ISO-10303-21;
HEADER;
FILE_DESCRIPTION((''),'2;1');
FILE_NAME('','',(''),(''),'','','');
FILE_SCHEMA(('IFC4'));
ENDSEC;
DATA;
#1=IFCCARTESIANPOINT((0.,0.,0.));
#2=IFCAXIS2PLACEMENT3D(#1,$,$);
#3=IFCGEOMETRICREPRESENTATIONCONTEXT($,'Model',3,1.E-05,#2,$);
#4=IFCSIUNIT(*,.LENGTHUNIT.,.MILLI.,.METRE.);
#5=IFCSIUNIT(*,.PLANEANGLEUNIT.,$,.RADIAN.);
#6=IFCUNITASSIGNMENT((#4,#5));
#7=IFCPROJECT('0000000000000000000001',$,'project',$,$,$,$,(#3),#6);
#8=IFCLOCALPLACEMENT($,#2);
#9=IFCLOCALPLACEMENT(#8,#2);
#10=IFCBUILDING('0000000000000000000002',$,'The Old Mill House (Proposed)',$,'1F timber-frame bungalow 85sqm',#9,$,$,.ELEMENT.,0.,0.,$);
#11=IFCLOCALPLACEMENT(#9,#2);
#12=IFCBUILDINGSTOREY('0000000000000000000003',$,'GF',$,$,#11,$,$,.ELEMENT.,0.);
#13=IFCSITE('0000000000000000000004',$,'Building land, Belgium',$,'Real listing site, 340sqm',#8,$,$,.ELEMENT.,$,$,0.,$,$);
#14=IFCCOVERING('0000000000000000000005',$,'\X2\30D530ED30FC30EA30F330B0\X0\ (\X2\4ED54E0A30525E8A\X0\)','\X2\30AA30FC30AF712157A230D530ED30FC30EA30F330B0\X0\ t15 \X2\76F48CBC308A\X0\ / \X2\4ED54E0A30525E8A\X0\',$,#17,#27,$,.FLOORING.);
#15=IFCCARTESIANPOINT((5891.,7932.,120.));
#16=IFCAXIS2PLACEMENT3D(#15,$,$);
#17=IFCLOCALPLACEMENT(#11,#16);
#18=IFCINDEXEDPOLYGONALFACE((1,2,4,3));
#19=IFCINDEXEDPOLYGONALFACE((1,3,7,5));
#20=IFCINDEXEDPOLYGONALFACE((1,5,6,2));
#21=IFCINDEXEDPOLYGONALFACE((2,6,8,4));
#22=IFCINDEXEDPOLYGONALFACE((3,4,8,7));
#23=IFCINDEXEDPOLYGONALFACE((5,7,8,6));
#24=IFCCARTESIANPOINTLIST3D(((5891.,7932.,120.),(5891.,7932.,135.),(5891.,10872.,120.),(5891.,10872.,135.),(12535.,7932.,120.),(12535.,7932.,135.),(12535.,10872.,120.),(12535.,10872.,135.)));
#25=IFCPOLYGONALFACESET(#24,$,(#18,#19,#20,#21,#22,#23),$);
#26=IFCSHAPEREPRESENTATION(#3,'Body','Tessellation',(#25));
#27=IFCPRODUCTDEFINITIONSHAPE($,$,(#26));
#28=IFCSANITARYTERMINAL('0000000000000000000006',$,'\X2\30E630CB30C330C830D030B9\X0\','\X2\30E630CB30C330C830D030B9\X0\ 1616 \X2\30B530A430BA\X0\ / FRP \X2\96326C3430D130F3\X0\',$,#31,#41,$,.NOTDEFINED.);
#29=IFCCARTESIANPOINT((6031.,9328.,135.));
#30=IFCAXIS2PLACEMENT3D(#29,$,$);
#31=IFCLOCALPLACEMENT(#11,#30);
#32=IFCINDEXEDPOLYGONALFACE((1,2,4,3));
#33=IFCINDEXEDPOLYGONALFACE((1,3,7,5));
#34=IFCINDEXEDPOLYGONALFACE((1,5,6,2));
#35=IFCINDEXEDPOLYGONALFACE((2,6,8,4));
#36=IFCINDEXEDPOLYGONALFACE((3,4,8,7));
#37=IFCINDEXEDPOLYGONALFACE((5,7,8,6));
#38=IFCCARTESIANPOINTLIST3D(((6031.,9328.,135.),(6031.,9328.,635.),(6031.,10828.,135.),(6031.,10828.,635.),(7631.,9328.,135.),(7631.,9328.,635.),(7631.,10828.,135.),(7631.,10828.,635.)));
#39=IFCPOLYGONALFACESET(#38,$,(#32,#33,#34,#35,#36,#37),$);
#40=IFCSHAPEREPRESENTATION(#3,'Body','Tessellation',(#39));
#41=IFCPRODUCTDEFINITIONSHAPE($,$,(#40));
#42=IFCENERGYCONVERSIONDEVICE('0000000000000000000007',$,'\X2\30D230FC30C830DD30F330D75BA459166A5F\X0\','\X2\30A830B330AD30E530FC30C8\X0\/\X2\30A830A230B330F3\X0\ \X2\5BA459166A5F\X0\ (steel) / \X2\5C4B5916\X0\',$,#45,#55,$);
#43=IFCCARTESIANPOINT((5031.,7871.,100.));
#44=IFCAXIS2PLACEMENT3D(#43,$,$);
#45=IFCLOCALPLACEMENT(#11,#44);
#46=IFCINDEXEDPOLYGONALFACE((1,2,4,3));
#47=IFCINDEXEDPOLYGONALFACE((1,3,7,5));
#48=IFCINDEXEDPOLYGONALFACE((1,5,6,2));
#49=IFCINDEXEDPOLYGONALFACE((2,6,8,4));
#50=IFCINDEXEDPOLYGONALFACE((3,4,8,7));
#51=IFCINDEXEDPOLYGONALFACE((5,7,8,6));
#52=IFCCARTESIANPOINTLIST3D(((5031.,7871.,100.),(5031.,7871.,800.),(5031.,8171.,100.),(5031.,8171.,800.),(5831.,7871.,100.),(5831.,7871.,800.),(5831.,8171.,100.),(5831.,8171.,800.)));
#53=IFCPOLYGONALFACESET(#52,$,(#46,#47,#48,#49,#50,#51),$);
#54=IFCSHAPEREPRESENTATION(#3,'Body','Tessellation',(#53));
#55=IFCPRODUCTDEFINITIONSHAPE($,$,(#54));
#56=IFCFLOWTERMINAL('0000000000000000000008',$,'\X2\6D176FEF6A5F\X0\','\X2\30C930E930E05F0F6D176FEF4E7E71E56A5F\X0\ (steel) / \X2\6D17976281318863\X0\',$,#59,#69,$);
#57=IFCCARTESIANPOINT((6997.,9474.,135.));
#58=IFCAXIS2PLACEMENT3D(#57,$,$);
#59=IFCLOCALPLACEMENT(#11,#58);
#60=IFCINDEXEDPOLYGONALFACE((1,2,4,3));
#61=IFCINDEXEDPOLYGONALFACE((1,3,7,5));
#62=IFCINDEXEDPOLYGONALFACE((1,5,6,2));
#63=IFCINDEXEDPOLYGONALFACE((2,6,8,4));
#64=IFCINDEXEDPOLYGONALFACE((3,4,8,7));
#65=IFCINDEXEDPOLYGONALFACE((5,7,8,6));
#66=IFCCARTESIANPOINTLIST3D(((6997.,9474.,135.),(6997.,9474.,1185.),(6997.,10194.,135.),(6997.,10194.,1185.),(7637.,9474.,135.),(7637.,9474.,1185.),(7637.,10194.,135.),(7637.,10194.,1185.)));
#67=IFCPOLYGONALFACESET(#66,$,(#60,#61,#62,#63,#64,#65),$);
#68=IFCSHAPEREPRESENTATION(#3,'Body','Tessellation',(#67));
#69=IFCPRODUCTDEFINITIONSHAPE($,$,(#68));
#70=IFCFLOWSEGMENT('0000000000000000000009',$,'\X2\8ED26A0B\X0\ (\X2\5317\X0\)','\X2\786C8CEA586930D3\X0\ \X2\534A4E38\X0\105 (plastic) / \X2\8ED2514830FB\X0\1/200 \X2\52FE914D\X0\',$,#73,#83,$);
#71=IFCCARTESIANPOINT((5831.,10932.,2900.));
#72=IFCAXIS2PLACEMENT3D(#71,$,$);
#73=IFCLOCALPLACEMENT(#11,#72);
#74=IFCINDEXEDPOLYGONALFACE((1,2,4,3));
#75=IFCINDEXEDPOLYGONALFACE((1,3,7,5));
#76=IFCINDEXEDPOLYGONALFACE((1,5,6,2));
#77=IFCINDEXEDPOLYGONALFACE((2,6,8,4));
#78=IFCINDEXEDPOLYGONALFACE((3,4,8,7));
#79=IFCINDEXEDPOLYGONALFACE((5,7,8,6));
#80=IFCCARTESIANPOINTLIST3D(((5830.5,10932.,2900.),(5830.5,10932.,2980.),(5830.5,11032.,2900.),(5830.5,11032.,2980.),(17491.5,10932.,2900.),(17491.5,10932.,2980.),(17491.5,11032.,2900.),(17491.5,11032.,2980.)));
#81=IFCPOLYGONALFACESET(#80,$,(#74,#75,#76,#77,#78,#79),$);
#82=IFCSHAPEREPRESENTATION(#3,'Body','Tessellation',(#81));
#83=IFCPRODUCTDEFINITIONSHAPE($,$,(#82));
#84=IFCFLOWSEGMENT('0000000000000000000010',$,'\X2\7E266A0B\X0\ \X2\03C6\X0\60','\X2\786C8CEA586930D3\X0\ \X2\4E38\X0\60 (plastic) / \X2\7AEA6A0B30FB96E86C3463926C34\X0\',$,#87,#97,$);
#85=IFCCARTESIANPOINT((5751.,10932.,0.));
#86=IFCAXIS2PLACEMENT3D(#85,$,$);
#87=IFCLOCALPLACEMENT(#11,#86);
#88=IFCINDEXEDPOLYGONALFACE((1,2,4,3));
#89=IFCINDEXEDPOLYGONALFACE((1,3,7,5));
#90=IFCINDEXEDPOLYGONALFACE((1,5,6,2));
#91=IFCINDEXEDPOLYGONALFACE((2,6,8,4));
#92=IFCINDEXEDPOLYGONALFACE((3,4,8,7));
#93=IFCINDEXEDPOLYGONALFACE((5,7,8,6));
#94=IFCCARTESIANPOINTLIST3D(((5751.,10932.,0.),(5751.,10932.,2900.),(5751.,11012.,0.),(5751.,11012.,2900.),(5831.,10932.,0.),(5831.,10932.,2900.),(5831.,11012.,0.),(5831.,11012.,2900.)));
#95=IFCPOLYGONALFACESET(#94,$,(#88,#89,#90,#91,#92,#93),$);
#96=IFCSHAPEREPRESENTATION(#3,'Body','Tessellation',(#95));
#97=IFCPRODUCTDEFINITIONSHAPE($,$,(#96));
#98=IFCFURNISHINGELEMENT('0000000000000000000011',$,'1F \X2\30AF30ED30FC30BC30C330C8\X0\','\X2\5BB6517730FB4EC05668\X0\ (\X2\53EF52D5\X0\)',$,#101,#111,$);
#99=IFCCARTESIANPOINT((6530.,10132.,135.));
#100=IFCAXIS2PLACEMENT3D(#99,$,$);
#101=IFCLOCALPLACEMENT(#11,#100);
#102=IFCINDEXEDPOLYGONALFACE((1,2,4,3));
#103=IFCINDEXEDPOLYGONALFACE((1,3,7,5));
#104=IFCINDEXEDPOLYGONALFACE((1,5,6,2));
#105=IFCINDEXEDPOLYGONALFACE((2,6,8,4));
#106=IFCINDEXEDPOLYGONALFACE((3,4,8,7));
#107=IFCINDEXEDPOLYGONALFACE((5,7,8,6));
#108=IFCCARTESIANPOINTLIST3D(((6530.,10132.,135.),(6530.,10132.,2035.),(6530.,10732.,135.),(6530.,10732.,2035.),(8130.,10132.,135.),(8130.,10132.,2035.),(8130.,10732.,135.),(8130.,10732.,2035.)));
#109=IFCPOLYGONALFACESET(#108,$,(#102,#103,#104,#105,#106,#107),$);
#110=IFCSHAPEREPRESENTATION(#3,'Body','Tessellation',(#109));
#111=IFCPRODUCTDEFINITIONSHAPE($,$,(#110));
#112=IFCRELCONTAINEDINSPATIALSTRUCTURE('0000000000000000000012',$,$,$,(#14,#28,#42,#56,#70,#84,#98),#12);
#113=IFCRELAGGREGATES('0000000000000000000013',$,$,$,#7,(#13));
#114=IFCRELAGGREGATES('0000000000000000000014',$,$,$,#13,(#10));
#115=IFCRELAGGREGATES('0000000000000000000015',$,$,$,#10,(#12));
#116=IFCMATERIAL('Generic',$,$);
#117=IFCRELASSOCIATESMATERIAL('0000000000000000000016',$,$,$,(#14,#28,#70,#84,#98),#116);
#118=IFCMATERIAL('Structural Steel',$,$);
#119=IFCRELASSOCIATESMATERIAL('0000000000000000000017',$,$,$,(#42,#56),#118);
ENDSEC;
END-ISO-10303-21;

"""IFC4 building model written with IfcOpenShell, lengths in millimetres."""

from ifc_helpers import new_model, si_unit, frame, frame_2d, origin, place, context, project, spatial, rectangle, extrude, material, element, save


model = new_model("IFC4")

# Units and contexts
model_context = context("Model", 3, precision=1e-05, world=origin())
ifc_project = project(units=[si_unit("LENGTHUNIT", "METRE", prefix="MILLI"), si_unit("PLANEANGLEUNIT", "RADIAN")], contexts=[model_context])

# Site, building, storey
site_placement = place(None, origin())
site = spatial("IfcSite", under=ifc_project, at=site_placement, Name="Building land, Belgium", ObjectType="Real listing site, 340sqm", CompositionType="ELEMENT", RefElevation=0.0)
building_placement = place(site_placement, origin())
building = spatial("IfcBuilding", under=site, at=building_placement, Name="The Old Mill House (Proposed)", ObjectType="1F timber-frame bungalow 85sqm", CompositionType="ELEMENT", ElevationOfRefHeight=0.0, ElevationOfTerrain=0.0)
storey_placement = place(building_placement, origin())
storey = spatial("IfcBuildingStorey", under=building, at=storey_placement, Name="GF", CompositionType="ELEMENT", Elevation=0.0)

# Shared definitions
ifc_material_1 = material(Name="Structural Steel")

# Covering
ifc_material_2 = material(Name="Generic")
covering_placement = place(storey_placement, frame((5891.0, 7932.0, 120.0)))
element("IfcCovering", 1, at=covering_placement, inside=storey, material=ifc_material_2, Name="フローリング (仕上げ床)", Description="オーク無垢フローリング t15 直貼り / 仕上げ床", PredefinedType="FLOORING", context=model_context, shape_type="SweptSolid", body=[
    extrude(rectangle(XDim=6644.0, YDim=2940.0, at=frame_2d((3322.0, 1470.0))), frame((5891.0, 7932.0, 120.0)), (0.0, 0.0, 1.0), 15.0),
])

# Sanitary terminal
sanitary_terminal_placement = place(storey_placement, frame((6031.0, 9328.0, 135.0)))
element("IfcSanitaryTerminal", 2, at=sanitary_terminal_placement, inside=storey, material=ifc_material_2, Name="ユニットバス", Description="ユニットバス 1616 サイズ / FRP 防水パン", PredefinedType="NOTDEFINED", context=model_context, shape_type="SweptSolid", body=[
    extrude(rectangle(XDim=1600.0, YDim=1500.0, at=frame_2d((800.0, 750.0))), frame((6031.0, 9328.0, 135.0)), (0.0, 0.0, 1.0), 500.0),
])

# Energy conversion device
energy_conversion_device_placement = place(storey_placement, frame((5031.0, 7871.0, 100.0)))
element("IfcEnergyConversionDevice", 3, at=energy_conversion_device_placement, inside=storey, material=ifc_material_1, Name="ヒートポンプ室外機", Description="エコキュート/エアコン 室外機 (steel) / 屋外", context=model_context, shape_type="SweptSolid", body=[
    extrude(rectangle(XDim=800.0, YDim=300.0, at=frame_2d((400.0, 150.0))), frame((5031.0, 7871.0, 100.0)), (0.0, 0.0, 1.0), 700.0),
])

# Flow terminal
flow_terminal_placement = place(storey_placement, frame((6997.0, 9474.0, 135.0)))
element("IfcFlowTerminal", 4, at=flow_terminal_placement, inside=storey, material=ifc_material_1, Name="洗濯機", Description="ドラム式洗濯乾燥機 (steel) / 洗面脱衣", context=model_context, shape_type="SweptSolid", body=[
    extrude(rectangle(XDim=640.0, YDim=720.0, at=frame_2d((320.0, 360.0))), frame((6997.0, 9474.0, 135.0)), (0.0, 0.0, 1.0), 1050.0),
])

# Flow segments
flow_segment_1_placement = place(storey_placement, frame((5831.0, 10932.0, 2900.0)))
element("IfcFlowSegment", 5, at=flow_segment_1_placement, inside=storey, material=ifc_material_2, Name="軒樋 (北)", Description="硬質塩ビ 半丸105 (plastic) / 軒先・1/200 勾配", context=model_context, shape_type="SweptSolid", body=[
    extrude(rectangle(XDim=11661.0, YDim=100.0, at=frame_2d((5830.0, 50.0))), frame((5831.0, 10932.0, 2900.0)), (0.0, 0.0, 1.0), 80.0),
])
flow_segment_2_placement = place(storey_placement, frame((5751.0, 10932.0, 0.0)))
element("IfcFlowSegment", 6, at=flow_segment_2_placement, inside=storey, material=ifc_material_2, Name="縦樋 φ60", Description="硬質塩ビ 丸60 (plastic) / 竪樋・雨水排水", context=model_context, shape_type="SweptSolid", body=[
    extrude(rectangle(XDim=80.0, YDim=80.0, at=frame_2d((40.0, 40.0))), frame((5751.0, 10932.0, 0.0)), (0.0, 0.0, 1.0), 2900.0),
])

# Furnishing element
furnishing_placement = place(storey_placement, frame((6530.0, 10132.0, 135.0)))
element("IfcFurnishingElement", 7, at=furnishing_placement, inside=storey, material=ifc_material_2, Name="1F クローゼット", Description="家具・什器 (可動)", context=model_context, shape_type="SweptSolid", body=[
    extrude(rectangle(XDim=1600.0, YDim=600.0, at=frame_2d((800.0, 300.0))), frame((6530.0, 10132.0, 135.0)), (0.0, 0.0, 1.0), 1900.0),
])

save(model, "model.ifc")
